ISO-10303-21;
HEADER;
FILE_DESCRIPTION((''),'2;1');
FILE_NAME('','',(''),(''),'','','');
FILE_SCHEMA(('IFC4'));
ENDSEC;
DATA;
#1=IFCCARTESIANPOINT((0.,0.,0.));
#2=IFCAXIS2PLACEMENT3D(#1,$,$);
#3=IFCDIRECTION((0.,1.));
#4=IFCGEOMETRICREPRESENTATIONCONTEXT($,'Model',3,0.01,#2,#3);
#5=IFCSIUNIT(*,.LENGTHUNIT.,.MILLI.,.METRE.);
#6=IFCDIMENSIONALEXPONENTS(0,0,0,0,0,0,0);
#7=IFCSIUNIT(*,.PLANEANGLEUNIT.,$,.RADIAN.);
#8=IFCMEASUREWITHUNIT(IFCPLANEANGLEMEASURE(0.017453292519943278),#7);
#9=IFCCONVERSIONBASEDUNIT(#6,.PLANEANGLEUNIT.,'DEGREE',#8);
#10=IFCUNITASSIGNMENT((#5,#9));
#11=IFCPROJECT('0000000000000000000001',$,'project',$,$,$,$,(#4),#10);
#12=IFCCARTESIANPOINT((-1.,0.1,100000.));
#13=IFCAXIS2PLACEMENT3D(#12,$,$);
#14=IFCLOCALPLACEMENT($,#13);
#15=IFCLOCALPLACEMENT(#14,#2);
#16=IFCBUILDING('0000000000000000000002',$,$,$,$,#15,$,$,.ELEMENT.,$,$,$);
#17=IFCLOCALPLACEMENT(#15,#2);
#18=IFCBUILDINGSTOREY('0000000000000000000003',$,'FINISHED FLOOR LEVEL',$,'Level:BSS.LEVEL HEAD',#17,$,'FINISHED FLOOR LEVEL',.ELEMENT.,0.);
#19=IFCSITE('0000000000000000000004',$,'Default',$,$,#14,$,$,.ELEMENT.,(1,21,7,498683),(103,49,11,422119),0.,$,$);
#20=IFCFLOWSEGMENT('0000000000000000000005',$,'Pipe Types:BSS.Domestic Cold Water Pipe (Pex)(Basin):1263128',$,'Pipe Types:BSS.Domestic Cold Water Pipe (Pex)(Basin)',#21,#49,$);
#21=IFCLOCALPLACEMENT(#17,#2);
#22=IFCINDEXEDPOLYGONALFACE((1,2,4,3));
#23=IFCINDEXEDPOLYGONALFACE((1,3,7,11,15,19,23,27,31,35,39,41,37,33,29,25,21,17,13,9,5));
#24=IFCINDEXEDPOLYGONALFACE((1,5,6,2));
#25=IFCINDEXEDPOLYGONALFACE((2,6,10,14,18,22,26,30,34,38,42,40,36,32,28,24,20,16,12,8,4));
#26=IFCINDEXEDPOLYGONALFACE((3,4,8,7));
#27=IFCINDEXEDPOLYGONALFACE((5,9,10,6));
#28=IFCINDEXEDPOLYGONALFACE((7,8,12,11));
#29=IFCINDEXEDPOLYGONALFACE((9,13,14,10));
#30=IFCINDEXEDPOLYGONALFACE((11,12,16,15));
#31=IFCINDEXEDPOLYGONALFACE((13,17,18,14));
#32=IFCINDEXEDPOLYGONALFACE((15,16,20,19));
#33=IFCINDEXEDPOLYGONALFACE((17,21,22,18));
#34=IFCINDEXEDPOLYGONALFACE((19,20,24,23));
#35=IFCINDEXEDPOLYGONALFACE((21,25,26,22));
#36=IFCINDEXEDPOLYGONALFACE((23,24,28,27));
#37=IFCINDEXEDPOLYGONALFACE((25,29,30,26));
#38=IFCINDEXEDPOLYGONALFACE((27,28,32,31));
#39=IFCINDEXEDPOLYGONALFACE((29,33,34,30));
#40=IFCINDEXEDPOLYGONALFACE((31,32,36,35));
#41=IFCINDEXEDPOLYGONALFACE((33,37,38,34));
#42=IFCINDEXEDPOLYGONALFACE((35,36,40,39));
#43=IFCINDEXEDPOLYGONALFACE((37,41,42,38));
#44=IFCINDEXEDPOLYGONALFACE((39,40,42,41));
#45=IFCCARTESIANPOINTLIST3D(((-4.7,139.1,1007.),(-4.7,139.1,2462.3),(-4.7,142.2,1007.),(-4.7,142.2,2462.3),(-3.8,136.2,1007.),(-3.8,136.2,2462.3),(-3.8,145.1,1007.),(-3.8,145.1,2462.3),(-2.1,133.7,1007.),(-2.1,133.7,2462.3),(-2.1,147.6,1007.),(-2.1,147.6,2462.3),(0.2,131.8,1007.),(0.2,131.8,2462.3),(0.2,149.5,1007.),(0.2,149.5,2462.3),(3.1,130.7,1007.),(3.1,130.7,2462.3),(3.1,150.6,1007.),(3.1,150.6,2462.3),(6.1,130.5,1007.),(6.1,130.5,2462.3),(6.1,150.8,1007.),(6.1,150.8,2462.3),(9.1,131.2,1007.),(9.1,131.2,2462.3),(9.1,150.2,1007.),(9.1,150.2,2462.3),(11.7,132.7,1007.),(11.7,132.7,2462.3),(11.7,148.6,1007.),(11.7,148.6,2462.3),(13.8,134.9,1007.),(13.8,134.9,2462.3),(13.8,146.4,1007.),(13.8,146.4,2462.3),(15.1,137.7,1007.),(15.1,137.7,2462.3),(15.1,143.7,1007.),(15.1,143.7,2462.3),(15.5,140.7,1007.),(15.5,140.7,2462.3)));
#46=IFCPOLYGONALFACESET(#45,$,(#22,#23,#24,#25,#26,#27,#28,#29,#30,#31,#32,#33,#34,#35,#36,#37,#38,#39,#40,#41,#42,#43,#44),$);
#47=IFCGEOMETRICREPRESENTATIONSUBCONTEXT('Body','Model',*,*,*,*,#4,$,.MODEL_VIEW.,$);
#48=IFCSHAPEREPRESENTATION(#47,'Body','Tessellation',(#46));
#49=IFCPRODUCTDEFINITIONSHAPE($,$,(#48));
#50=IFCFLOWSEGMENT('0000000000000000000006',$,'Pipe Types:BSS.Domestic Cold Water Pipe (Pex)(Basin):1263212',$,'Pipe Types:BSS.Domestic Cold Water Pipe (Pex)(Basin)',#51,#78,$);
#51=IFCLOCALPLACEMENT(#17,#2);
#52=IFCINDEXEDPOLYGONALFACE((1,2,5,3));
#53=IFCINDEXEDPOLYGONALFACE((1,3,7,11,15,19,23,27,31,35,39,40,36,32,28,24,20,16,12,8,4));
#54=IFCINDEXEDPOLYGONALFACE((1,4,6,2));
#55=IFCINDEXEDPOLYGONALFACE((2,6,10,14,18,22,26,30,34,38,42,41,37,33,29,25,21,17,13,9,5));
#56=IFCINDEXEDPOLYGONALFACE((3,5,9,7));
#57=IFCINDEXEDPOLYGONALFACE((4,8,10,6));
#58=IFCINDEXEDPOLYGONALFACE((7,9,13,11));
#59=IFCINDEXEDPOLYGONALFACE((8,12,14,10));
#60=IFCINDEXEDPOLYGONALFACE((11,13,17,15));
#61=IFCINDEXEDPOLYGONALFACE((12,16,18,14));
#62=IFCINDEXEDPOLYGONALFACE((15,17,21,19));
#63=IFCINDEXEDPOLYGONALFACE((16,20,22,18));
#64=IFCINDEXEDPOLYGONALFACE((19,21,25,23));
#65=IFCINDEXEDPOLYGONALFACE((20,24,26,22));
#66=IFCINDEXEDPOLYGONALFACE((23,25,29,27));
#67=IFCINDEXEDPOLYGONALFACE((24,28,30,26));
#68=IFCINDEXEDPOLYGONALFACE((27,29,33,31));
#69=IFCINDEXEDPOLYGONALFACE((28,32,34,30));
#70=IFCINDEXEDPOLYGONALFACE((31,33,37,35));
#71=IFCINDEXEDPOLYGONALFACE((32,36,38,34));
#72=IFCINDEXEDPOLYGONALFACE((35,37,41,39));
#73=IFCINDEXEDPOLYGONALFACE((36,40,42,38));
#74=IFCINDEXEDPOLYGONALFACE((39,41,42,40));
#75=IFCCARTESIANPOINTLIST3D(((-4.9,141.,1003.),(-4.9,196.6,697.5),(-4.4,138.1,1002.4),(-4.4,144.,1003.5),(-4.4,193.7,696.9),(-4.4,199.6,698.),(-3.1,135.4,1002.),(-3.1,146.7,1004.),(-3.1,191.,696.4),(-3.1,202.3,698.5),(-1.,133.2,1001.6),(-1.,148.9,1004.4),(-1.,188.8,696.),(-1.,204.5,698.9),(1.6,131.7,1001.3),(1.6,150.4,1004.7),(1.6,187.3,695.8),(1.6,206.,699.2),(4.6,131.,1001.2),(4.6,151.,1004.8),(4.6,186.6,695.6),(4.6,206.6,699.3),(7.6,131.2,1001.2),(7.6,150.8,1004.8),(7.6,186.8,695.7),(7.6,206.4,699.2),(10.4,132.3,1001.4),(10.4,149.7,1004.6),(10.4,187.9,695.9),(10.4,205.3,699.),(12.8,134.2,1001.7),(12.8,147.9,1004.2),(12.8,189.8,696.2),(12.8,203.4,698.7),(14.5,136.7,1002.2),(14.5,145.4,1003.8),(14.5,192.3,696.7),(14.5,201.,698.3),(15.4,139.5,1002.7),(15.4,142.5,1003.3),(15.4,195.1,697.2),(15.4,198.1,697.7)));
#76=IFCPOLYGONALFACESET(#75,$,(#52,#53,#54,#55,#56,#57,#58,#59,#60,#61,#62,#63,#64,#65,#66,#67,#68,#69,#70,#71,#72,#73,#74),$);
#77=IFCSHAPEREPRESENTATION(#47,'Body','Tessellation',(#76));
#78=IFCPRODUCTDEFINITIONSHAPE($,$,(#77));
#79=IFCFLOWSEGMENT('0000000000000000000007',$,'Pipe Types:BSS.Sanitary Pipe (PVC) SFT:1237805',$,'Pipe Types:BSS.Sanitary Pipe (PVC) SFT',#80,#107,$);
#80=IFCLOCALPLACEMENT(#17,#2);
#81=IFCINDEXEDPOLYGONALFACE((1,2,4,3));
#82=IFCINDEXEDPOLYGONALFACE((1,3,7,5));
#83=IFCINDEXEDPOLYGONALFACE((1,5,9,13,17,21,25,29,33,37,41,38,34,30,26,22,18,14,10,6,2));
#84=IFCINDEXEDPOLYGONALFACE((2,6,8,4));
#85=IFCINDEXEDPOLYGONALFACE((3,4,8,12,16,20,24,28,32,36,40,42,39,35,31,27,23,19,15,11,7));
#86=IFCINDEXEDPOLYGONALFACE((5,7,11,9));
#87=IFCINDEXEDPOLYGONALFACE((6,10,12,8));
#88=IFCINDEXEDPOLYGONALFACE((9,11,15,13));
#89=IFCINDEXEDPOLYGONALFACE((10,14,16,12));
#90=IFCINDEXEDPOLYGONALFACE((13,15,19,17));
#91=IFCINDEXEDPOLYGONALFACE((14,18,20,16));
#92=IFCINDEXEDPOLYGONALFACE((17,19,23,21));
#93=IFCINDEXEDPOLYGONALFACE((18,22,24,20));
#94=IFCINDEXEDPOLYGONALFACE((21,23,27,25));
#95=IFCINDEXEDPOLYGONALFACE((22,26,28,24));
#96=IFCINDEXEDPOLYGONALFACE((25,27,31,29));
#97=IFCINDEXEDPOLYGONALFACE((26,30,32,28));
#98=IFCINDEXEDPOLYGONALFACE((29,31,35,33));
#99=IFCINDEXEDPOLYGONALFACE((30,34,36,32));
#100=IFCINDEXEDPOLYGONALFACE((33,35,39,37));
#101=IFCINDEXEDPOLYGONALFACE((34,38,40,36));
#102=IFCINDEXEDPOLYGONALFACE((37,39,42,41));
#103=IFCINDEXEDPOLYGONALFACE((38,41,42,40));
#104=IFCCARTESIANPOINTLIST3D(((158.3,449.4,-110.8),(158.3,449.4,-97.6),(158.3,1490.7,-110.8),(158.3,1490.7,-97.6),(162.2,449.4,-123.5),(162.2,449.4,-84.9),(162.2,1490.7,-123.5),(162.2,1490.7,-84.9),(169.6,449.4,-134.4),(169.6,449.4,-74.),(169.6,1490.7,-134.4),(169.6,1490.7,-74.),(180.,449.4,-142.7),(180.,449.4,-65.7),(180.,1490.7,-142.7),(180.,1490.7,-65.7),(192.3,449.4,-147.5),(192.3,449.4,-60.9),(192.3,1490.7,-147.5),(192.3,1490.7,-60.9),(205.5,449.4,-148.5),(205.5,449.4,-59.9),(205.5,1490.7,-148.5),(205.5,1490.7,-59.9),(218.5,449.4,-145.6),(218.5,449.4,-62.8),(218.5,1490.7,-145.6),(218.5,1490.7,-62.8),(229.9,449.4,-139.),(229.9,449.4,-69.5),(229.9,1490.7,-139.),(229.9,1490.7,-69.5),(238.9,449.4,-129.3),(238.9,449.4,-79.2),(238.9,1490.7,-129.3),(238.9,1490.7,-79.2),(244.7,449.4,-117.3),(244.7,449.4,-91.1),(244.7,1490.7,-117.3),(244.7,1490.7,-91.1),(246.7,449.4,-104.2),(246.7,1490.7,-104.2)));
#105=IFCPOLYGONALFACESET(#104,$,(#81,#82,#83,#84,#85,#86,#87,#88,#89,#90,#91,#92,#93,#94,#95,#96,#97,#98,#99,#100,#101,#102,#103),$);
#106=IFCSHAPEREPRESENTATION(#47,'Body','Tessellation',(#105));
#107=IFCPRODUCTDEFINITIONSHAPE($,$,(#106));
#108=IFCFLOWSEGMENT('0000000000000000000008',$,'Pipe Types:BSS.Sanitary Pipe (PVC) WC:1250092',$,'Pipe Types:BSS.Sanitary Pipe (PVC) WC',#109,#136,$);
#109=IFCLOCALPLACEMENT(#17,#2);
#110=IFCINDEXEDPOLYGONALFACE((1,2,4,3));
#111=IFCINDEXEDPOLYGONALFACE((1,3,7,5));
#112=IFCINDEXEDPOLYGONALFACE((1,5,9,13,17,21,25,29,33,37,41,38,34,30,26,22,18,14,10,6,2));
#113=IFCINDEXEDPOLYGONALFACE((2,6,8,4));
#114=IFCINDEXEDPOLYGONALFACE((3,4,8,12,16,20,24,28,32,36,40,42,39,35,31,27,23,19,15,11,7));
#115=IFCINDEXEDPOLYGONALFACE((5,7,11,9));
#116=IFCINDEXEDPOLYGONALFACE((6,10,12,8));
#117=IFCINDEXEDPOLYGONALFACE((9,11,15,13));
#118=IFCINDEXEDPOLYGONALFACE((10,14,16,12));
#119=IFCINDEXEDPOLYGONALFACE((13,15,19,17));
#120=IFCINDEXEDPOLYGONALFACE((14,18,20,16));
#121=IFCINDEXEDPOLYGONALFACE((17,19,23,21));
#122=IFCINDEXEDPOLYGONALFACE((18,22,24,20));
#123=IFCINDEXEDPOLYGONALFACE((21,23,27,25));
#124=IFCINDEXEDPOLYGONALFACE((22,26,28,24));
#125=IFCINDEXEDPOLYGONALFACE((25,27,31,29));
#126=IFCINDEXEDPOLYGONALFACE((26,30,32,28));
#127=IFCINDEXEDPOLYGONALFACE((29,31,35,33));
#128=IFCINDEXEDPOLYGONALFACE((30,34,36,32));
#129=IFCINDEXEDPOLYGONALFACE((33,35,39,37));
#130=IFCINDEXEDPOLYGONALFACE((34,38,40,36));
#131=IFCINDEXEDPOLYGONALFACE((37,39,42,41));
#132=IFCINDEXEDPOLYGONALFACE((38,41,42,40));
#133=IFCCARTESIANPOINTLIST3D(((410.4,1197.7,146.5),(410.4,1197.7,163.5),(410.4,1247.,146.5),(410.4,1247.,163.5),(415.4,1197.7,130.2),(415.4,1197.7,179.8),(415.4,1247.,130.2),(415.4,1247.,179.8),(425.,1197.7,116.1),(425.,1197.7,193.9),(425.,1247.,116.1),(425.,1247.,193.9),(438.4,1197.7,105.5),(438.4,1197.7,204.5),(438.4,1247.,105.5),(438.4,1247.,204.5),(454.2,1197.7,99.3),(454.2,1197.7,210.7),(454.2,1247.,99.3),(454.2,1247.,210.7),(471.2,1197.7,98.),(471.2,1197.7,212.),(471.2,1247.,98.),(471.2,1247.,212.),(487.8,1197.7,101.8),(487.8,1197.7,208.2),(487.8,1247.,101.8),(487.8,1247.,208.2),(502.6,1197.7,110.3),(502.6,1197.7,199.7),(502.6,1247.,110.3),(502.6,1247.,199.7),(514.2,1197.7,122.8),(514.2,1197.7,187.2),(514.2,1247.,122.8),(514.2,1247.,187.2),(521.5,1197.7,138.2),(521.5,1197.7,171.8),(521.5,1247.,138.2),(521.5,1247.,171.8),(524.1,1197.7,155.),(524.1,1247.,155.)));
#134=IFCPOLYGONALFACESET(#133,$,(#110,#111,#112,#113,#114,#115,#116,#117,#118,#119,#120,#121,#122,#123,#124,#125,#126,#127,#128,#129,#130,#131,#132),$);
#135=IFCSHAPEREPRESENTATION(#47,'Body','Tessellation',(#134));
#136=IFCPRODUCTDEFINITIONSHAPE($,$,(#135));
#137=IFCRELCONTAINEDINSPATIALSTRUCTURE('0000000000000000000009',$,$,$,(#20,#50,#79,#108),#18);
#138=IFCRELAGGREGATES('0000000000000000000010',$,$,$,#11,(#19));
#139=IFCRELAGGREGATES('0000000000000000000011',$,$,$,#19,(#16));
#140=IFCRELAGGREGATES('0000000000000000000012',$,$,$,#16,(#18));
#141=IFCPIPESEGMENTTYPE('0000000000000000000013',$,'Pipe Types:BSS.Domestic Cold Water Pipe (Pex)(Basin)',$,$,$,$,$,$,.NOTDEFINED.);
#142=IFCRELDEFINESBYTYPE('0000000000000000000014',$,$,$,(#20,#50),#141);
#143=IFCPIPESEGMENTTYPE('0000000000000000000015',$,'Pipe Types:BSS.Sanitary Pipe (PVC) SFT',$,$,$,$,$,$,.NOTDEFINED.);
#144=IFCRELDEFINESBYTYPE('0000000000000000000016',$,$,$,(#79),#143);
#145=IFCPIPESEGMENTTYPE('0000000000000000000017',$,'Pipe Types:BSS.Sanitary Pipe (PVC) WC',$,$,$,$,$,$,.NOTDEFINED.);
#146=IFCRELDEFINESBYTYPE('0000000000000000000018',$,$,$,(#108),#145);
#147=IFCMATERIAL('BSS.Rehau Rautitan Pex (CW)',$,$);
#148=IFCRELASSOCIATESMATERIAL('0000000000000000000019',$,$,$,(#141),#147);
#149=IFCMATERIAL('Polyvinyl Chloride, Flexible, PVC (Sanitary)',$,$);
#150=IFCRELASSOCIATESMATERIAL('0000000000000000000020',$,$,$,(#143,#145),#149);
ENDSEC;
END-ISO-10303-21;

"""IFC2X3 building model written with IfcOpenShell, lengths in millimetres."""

from ifc_helpers import new_model, entity, si_unit, converted_unit, direction, frame, frame_2d, origin, place, context, subcontext, project, spatial, circle, extrude, material, type_object, element, save


model = new_model("IFC2X3")

# Units and contexts
model_context = context("Model", 3, precision=0.01, world=origin(), true_north=direction((0.0, 1.0)))
body_context = subcontext(model_context, "Body", "Model", "MODEL_VIEW")
ifc_project = project(units=[si_unit("LENGTHUNIT", "METRE", prefix="MILLI"), converted_unit("PLANEANGLEUNIT", "DEGREE", entity("IfcPlaneAngleMeasure", 0.017453292519943278), si_unit("PLANEANGLEUNIT", "RADIAN"), dimensions=[0, 0, 0, 0, 0, 0, 0])], contexts=[model_context])

# Site, building, storey
site_placement = place(None, frame((-1.0, 0.1, 100000.0)))
site = spatial("IfcSite", under=ifc_project, at=site_placement, Name="Default", CompositionType="ELEMENT", RefLatitude=(1, 21, 7, 498683), RefLongitude=(103, 49, 11, 422119), RefElevation=0.0)
building_placement = place(site_placement, origin())
building = spatial("IfcBuilding", under=site, at=building_placement, CompositionType="ELEMENT")
storey_placement = place(building_placement, origin())
storey = spatial("IfcBuildingStorey", under=building, at=storey_placement, Name="FINISHED FLOOR LEVEL", ObjectType="Level:BSS.LEVEL HEAD", LongName="FINISHED FLOOR LEVEL", CompositionType="ELEMENT", Elevation=0.0)

# Flow segments
ifc_material_1 = material(Name="BSS.Rehau Rautitan Pex (CW)")
pipe_segment_type_1 = type_object("IfcPipeSegmentType", Name="Pipe Types:BSS.Domestic Cold Water Pipe (Pex)(Basin)", PredefinedType="NOTDEFINED", material=ifc_material_1)
flow_segment_1_placement = place(storey_placement, origin())
element("IfcFlowSegment", 1, at=flow_segment_1_placement, inside=storey, type_object=pipe_segment_type_1, Name="Pipe Types:BSS.Domestic Cold Water Pipe (Pex)(Basin):1263128", ObjectType="Pipe Types:BSS.Domestic Cold Water Pipe (Pex)(Basin)", context=body_context, shape_type="SweptSolid", body=[
    extrude(circle(Radius=10.2, at=frame_2d((0.0, 0.0), x_axis=(1.0, 0.0))), frame((5.3, 140.7, 1007.0)), (0.0, 0.0, 1.0), 1455.3),
])
flow_segment_2_placement = place(storey_placement, origin())
element("IfcFlowSegment", 2, at=flow_segment_2_placement, inside=storey, type_object=pipe_segment_type_1, Name="Pipe Types:BSS.Domestic Cold Water Pipe (Pex)(Basin):1263212", ObjectType="Pipe Types:BSS.Domestic Cold Water Pipe (Pex)(Basin)", context=body_context, shape_type="SweptSolid", body=[
    extrude(circle(Radius=10.2, at=frame_2d((0.0, 0.0), x_axis=(1.0, 0.0))), frame((5.3, 196.6, 697.5), z_axis=(0.0, -0.178966, 0.983855), x_axis=(-1.0, 0.0, 0.0)), (0.0, 0.0, 1.0), 310.5),
])
ifc_material_2 = material(Name="Polyvinyl Chloride, Flexible, PVC (Sanitary)")
pipe_segment_type_2 = type_object("IfcPipeSegmentType", Name="Pipe Types:BSS.Sanitary Pipe (PVC) SFT", PredefinedType="NOTDEFINED", material=ifc_material_2)
flow_segment_3_placement = place(storey_placement, origin())
element("IfcFlowSegment", 3, at=flow_segment_3_placement, inside=storey, type_object=pipe_segment_type_2, Name="Pipe Types:BSS.Sanitary Pipe (PVC) SFT:1237805", ObjectType="Pipe Types:BSS.Sanitary Pipe (PVC) SFT", context=body_context, shape_type="SweptSolid", body=[
    extrude(circle(Radius=44.5, at=frame_2d((0.0, 0.0), x_axis=(1.0, 0.0))), frame((202.2, 449.4, -104.2), z_axis=(0.0, 1.0, 0.0), x_axis=(1.0, 0.0, 0.0)), (0.0, 0.0, 1.0), 1041.2),
])
pipe_segment_type_3 = type_object("IfcPipeSegmentType", Name="Pipe Types:BSS.Sanitary Pipe (PVC) WC", PredefinedType="NOTDEFINED", material=ifc_material_2)
flow_segment_4_placement = place(storey_placement, origin())
element("IfcFlowSegment", 4, at=flow_segment_4_placement, inside=storey, type_object=pipe_segment_type_3, Name="Pipe Types:BSS.Sanitary Pipe (PVC) WC:1250092", ObjectType="Pipe Types:BSS.Sanitary Pipe (PVC) WC", context=body_context, shape_type="SweptSolid", body=[
    extrude(circle(Radius=57.2, at=frame_2d((0.0, 0.0), x_axis=(1.0, 0.0))), frame((466.9, 1197.7, 155.0), z_axis=(0.0, 1.0, 0.0), x_axis=(1.0, 0.0, 0.0)), (0.0, 0.0, 1.0), 49.2),
])

save(model, "model.ifc")
